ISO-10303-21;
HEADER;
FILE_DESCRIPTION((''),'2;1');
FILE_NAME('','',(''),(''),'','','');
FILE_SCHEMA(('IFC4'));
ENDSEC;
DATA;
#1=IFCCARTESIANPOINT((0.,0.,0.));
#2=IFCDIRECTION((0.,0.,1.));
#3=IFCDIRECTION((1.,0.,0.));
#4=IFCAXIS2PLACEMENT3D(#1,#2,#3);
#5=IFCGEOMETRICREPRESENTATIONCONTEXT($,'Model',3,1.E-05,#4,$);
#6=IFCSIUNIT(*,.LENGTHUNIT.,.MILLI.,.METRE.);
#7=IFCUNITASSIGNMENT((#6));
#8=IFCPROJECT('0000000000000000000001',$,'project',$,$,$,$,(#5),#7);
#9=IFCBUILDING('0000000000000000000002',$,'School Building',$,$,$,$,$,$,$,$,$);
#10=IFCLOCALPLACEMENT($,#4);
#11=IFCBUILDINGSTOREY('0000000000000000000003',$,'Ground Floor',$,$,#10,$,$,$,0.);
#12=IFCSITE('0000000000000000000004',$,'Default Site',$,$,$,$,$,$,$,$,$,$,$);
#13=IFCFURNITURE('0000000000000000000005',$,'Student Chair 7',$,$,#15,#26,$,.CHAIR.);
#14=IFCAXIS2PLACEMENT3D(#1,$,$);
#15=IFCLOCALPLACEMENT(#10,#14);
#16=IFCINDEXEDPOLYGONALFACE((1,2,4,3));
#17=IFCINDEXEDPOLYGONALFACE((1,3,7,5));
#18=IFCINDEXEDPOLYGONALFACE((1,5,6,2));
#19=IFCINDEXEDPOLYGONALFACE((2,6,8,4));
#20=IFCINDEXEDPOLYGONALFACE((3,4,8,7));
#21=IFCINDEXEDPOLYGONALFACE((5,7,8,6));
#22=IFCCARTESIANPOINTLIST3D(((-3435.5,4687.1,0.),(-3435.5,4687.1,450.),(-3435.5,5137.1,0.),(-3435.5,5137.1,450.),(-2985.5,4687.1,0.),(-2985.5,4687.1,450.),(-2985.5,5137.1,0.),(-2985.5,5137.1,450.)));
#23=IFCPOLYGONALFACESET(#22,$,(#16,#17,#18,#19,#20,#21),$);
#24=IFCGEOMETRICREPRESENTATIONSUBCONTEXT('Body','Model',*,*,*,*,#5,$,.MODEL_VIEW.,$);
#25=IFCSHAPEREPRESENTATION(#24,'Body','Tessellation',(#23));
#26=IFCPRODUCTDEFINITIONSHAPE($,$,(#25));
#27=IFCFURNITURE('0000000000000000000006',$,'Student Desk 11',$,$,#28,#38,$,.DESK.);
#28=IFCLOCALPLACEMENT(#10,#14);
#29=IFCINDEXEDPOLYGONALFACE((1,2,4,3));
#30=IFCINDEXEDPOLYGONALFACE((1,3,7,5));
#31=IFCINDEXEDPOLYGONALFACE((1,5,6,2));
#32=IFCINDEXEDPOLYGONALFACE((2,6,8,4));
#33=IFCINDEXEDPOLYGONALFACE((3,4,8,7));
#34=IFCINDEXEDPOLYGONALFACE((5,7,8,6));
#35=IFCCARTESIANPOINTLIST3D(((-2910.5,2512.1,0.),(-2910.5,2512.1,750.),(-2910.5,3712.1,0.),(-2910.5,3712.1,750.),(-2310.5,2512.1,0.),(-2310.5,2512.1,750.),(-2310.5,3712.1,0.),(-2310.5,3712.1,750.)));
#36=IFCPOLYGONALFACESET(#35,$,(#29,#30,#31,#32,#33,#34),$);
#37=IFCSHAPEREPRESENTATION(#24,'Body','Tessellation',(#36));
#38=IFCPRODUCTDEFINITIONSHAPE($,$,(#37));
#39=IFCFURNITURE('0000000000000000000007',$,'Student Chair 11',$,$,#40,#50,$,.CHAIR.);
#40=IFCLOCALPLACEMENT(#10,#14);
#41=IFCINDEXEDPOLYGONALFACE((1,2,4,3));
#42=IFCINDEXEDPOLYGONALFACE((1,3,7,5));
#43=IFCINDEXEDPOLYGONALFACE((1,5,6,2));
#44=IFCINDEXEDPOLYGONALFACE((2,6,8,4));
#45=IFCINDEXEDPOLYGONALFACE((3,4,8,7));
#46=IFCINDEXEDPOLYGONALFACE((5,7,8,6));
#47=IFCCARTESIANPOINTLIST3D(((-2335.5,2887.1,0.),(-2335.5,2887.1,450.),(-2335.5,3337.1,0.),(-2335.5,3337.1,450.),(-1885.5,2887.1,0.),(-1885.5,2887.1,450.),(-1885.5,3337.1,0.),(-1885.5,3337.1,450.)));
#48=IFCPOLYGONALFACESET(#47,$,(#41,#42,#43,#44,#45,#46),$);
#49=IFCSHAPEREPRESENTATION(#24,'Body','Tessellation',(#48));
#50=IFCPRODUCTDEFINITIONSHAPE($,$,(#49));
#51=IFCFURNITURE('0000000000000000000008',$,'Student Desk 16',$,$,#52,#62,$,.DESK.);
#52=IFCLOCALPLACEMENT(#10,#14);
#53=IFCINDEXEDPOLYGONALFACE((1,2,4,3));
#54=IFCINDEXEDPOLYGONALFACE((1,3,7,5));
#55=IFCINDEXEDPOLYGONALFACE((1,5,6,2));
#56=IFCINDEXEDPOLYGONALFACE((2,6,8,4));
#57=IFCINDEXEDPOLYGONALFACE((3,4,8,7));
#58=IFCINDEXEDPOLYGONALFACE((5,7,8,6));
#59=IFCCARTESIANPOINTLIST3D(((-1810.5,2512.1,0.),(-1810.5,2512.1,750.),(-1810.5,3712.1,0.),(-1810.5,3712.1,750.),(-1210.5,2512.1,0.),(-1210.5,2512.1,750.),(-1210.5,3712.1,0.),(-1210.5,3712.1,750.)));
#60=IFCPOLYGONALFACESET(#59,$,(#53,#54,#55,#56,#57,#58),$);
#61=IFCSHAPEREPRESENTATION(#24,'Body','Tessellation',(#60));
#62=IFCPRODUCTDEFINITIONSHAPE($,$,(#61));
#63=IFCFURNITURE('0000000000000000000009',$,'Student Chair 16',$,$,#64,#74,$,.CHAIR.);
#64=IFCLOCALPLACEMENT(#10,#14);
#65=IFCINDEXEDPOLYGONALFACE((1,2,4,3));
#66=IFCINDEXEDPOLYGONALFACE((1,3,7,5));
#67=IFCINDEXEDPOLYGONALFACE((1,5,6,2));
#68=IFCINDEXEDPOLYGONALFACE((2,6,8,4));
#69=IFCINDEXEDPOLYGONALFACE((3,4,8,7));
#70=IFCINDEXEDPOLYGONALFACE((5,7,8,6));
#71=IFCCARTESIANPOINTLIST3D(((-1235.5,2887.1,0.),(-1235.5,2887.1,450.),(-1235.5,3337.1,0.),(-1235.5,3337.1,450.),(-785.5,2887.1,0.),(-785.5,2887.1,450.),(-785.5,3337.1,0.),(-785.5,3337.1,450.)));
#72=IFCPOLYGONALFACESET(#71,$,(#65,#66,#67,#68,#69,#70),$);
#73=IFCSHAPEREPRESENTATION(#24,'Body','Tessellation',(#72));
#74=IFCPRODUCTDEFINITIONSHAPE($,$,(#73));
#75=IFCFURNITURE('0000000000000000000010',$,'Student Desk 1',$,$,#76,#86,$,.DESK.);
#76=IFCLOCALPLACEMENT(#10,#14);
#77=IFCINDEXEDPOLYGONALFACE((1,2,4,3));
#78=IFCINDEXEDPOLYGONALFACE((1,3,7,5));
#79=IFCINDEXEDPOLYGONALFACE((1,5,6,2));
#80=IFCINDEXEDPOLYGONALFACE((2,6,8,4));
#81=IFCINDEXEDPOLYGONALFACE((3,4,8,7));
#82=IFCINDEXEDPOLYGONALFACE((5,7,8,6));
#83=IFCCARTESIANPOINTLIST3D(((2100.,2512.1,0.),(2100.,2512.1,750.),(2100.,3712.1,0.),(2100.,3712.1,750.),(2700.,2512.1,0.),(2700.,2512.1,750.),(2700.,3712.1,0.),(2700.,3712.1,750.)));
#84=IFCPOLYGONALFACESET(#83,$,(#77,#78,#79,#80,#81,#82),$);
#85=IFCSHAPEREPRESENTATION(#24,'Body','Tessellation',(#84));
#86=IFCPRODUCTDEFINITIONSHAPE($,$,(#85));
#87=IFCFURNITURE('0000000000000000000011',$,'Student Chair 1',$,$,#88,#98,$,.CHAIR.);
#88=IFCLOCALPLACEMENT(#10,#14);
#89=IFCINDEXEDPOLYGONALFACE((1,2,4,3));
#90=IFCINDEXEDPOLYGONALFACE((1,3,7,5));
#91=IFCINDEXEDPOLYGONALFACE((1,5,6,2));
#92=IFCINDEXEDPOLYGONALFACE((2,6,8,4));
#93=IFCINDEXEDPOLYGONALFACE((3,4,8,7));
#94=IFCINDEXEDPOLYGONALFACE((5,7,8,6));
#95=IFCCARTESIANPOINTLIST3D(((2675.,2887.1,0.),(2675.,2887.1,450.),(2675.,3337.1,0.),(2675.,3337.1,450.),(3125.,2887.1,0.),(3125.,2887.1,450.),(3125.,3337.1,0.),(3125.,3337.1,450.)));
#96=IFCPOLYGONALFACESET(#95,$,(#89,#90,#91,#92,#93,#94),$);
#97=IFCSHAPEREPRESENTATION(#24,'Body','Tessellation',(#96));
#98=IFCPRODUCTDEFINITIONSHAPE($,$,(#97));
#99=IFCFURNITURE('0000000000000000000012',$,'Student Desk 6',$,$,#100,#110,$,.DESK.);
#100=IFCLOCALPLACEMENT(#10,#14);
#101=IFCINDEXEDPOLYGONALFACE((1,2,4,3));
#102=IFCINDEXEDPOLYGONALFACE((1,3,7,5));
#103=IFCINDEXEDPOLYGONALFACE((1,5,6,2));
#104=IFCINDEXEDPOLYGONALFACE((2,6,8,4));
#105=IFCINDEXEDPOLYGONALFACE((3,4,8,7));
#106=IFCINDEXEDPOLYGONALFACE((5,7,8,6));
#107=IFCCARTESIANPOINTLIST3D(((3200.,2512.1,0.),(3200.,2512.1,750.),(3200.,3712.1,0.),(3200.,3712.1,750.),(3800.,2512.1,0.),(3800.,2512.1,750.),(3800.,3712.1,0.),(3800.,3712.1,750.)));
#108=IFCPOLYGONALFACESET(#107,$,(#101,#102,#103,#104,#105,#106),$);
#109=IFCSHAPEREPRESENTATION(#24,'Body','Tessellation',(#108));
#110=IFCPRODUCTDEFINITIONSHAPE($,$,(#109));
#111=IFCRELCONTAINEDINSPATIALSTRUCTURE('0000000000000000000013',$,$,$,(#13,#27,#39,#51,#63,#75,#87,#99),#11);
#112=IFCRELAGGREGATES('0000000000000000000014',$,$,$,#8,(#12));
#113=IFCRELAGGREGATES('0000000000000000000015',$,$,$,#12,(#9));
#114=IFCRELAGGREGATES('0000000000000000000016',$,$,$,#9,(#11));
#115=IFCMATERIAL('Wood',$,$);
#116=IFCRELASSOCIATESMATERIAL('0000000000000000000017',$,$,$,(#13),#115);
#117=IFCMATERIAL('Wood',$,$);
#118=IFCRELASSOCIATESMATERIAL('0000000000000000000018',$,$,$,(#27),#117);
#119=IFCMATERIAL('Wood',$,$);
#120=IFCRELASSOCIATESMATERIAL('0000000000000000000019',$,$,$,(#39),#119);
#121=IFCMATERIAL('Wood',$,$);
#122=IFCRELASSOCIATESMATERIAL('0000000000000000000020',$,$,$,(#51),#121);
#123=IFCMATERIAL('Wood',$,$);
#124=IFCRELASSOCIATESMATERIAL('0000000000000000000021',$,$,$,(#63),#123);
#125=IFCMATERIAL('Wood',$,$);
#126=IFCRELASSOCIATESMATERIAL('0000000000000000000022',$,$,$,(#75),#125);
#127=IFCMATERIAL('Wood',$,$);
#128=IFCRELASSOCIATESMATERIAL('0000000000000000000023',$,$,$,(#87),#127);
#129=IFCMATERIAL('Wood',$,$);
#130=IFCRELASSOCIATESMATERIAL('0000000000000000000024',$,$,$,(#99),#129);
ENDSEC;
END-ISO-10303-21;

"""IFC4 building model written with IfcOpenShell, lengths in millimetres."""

from ifc_helpers import new_model, si_unit, frame, origin_with_axes, origin_2d, place, context, subcontext, project, spatial, rectangle, extrude, material, element, save


model = new_model("IFC4")

# Units and contexts
model_context = context("Model", 3, precision=1e-05, world=origin_with_axes())
body_context = subcontext(model_context, "Body", "Model", "MODEL_VIEW")
ifc_project = project(units=[si_unit("LENGTHUNIT", "METRE", prefix="MILLI")], contexts=[model_context])

# Site, building, storey
site = spatial("IfcSite", under=ifc_project, Name="Default Site")
building = spatial("IfcBuilding", under=site, Name="School Building")
storey_placement = place(None, origin_with_axes())
storey = spatial("IfcBuildingStorey", under=building, at=storey_placement, Name="Ground Floor", Elevation=0.0)

# Furniture
ifc_material_1 = material(Name="Wood")
furniture_1_placement = place(storey_placement, frame((-3210.5, 4912.1, 0.0), z_axis=(0.0, 0.0, 1.0), x_axis=(1.0, 0.0, 0.0)))
element("IfcFurniture", 1, at=furniture_1_placement, inside=storey, material=ifc_material_1, Name="Student Chair 7", PredefinedType="CHAIR", context=body_context, shape_type="SweptSolid", body=[
    extrude(rectangle(XDim=450.0, YDim=450.0, at=origin_2d()), origin_with_axes(), (0.0, 0.0, 1.0), 450.0),
])
ifc_material_2 = material(Name="Wood")
furniture_2_placement = place(storey_placement, frame((-2610.5, 3112.1, 0.0), z_axis=(0.0, 0.0, 1.0), x_axis=(0.0, 1.0, 0.0)))
element("IfcFurniture", 2, at=furniture_2_placement, inside=storey, material=ifc_material_2, Name="Student Desk 11", PredefinedType="DESK", context=body_context, shape_type="SweptSolid", body=[
    extrude(rectangle(XDim=1200.0, YDim=600.0, at=origin_2d()), origin_with_axes(), (0.0, 0.0, 1.0), 750.0),
])
ifc_material_3 = material(Name="Wood")
furniture_3_placement = place(storey_placement, frame((-2110.5, 3112.1, 0.0), z_axis=(0.0, 0.0, 1.0), x_axis=(1.0, 0.0, 0.0)))
element("IfcFurniture", 3, at=furniture_3_placement, inside=storey, material=ifc_material_3, Name="Student Chair 11", PredefinedType="CHAIR", context=body_context, shape_type="SweptSolid", body=[
    extrude(rectangle(XDim=450.0, YDim=450.0, at=origin_2d()), origin_with_axes(), (0.0, 0.0, 1.0), 450.0),
])
ifc_material_4 = material(Name="Wood")
furniture_4_placement = place(storey_placement, frame((-1510.5, 3112.1, 0.0), z_axis=(0.0, 0.0, 1.0), x_axis=(0.0, 1.0, 0.0)))
element("IfcFurniture", 4, at=furniture_4_placement, inside=storey, material=ifc_material_4, Name="Student Desk 16", PredefinedType="DESK", context=body_context, shape_type="SweptSolid", body=[
    extrude(rectangle(XDim=1200.0, YDim=600.0, at=origin_2d()), origin_with_axes(), (0.0, 0.0, 1.0), 750.0),
])
ifc_material_5 = material(Name="Wood")
furniture_5_placement = place(storey_placement, frame((-1010.5, 3112.1, 0.0), z_axis=(0.0, 0.0, 1.0), x_axis=(1.0, 0.0, 0.0)))
element("IfcFurniture", 5, at=furniture_5_placement, inside=storey, material=ifc_material_5, Name="Student Chair 16", PredefinedType="CHAIR", context=body_context, shape_type="SweptSolid", body=[
    extrude(rectangle(XDim=450.0, YDim=450.0, at=origin_2d()), origin_with_axes(), (0.0, 0.0, 1.0), 450.0),
])
ifc_material_6 = material(Name="Wood")
furniture_6_placement = place(storey_placement, frame((2400.0, 3112.1, 0.0), z_axis=(0.0, 0.0, 1.0), x_axis=(0.0, 1.0, 0.0)))
element("IfcFurniture", 6, at=furniture_6_placement, inside=storey, material=ifc_material_6, Name="Student Desk 1", PredefinedType="DESK", context=body_context, shape_type="SweptSolid", body=[
    extrude(rectangle(XDim=1200.0, YDim=600.0, at=origin_2d()), origin_with_axes(), (0.0, 0.0, 1.0), 750.0),
])
ifc_material_7 = material(Name="Wood")
furniture_7_placement = place(storey_placement, frame((2900.0, 3112.1, 0.0), z_axis=(0.0, 0.0, 1.0), x_axis=(1.0, 0.0, 0.0)))
element("IfcFurniture", 7, at=furniture_7_placement, inside=storey, material=ifc_material_7, Name="Student Chair 1", PredefinedType="CHAIR", context=body_context, shape_type="SweptSolid", body=[
    extrude(rectangle(XDim=450.0, YDim=450.0, at=origin_2d()), origin_with_axes(), (0.0, 0.0, 1.0), 450.0),
])
ifc_material_8 = material(Name="Wood")
furniture_8_placement = place(storey_placement, frame((3500.0, 3112.1, 0.0), z_axis=(0.0, 0.0, 1.0), x_axis=(0.0, 1.0, 0.0)))
element("IfcFurniture", 8, at=furniture_8_placement, inside=storey, material=ifc_material_8, Name="Student Desk 6", PredefinedType="DESK", context=body_context, shape_type="SweptSolid", body=[
    extrude(rectangle(XDim=1200.0, YDim=600.0, at=origin_2d()), origin_with_axes(), (0.0, 0.0, 1.0), 750.0),
])

save(model, "model.ifc")
